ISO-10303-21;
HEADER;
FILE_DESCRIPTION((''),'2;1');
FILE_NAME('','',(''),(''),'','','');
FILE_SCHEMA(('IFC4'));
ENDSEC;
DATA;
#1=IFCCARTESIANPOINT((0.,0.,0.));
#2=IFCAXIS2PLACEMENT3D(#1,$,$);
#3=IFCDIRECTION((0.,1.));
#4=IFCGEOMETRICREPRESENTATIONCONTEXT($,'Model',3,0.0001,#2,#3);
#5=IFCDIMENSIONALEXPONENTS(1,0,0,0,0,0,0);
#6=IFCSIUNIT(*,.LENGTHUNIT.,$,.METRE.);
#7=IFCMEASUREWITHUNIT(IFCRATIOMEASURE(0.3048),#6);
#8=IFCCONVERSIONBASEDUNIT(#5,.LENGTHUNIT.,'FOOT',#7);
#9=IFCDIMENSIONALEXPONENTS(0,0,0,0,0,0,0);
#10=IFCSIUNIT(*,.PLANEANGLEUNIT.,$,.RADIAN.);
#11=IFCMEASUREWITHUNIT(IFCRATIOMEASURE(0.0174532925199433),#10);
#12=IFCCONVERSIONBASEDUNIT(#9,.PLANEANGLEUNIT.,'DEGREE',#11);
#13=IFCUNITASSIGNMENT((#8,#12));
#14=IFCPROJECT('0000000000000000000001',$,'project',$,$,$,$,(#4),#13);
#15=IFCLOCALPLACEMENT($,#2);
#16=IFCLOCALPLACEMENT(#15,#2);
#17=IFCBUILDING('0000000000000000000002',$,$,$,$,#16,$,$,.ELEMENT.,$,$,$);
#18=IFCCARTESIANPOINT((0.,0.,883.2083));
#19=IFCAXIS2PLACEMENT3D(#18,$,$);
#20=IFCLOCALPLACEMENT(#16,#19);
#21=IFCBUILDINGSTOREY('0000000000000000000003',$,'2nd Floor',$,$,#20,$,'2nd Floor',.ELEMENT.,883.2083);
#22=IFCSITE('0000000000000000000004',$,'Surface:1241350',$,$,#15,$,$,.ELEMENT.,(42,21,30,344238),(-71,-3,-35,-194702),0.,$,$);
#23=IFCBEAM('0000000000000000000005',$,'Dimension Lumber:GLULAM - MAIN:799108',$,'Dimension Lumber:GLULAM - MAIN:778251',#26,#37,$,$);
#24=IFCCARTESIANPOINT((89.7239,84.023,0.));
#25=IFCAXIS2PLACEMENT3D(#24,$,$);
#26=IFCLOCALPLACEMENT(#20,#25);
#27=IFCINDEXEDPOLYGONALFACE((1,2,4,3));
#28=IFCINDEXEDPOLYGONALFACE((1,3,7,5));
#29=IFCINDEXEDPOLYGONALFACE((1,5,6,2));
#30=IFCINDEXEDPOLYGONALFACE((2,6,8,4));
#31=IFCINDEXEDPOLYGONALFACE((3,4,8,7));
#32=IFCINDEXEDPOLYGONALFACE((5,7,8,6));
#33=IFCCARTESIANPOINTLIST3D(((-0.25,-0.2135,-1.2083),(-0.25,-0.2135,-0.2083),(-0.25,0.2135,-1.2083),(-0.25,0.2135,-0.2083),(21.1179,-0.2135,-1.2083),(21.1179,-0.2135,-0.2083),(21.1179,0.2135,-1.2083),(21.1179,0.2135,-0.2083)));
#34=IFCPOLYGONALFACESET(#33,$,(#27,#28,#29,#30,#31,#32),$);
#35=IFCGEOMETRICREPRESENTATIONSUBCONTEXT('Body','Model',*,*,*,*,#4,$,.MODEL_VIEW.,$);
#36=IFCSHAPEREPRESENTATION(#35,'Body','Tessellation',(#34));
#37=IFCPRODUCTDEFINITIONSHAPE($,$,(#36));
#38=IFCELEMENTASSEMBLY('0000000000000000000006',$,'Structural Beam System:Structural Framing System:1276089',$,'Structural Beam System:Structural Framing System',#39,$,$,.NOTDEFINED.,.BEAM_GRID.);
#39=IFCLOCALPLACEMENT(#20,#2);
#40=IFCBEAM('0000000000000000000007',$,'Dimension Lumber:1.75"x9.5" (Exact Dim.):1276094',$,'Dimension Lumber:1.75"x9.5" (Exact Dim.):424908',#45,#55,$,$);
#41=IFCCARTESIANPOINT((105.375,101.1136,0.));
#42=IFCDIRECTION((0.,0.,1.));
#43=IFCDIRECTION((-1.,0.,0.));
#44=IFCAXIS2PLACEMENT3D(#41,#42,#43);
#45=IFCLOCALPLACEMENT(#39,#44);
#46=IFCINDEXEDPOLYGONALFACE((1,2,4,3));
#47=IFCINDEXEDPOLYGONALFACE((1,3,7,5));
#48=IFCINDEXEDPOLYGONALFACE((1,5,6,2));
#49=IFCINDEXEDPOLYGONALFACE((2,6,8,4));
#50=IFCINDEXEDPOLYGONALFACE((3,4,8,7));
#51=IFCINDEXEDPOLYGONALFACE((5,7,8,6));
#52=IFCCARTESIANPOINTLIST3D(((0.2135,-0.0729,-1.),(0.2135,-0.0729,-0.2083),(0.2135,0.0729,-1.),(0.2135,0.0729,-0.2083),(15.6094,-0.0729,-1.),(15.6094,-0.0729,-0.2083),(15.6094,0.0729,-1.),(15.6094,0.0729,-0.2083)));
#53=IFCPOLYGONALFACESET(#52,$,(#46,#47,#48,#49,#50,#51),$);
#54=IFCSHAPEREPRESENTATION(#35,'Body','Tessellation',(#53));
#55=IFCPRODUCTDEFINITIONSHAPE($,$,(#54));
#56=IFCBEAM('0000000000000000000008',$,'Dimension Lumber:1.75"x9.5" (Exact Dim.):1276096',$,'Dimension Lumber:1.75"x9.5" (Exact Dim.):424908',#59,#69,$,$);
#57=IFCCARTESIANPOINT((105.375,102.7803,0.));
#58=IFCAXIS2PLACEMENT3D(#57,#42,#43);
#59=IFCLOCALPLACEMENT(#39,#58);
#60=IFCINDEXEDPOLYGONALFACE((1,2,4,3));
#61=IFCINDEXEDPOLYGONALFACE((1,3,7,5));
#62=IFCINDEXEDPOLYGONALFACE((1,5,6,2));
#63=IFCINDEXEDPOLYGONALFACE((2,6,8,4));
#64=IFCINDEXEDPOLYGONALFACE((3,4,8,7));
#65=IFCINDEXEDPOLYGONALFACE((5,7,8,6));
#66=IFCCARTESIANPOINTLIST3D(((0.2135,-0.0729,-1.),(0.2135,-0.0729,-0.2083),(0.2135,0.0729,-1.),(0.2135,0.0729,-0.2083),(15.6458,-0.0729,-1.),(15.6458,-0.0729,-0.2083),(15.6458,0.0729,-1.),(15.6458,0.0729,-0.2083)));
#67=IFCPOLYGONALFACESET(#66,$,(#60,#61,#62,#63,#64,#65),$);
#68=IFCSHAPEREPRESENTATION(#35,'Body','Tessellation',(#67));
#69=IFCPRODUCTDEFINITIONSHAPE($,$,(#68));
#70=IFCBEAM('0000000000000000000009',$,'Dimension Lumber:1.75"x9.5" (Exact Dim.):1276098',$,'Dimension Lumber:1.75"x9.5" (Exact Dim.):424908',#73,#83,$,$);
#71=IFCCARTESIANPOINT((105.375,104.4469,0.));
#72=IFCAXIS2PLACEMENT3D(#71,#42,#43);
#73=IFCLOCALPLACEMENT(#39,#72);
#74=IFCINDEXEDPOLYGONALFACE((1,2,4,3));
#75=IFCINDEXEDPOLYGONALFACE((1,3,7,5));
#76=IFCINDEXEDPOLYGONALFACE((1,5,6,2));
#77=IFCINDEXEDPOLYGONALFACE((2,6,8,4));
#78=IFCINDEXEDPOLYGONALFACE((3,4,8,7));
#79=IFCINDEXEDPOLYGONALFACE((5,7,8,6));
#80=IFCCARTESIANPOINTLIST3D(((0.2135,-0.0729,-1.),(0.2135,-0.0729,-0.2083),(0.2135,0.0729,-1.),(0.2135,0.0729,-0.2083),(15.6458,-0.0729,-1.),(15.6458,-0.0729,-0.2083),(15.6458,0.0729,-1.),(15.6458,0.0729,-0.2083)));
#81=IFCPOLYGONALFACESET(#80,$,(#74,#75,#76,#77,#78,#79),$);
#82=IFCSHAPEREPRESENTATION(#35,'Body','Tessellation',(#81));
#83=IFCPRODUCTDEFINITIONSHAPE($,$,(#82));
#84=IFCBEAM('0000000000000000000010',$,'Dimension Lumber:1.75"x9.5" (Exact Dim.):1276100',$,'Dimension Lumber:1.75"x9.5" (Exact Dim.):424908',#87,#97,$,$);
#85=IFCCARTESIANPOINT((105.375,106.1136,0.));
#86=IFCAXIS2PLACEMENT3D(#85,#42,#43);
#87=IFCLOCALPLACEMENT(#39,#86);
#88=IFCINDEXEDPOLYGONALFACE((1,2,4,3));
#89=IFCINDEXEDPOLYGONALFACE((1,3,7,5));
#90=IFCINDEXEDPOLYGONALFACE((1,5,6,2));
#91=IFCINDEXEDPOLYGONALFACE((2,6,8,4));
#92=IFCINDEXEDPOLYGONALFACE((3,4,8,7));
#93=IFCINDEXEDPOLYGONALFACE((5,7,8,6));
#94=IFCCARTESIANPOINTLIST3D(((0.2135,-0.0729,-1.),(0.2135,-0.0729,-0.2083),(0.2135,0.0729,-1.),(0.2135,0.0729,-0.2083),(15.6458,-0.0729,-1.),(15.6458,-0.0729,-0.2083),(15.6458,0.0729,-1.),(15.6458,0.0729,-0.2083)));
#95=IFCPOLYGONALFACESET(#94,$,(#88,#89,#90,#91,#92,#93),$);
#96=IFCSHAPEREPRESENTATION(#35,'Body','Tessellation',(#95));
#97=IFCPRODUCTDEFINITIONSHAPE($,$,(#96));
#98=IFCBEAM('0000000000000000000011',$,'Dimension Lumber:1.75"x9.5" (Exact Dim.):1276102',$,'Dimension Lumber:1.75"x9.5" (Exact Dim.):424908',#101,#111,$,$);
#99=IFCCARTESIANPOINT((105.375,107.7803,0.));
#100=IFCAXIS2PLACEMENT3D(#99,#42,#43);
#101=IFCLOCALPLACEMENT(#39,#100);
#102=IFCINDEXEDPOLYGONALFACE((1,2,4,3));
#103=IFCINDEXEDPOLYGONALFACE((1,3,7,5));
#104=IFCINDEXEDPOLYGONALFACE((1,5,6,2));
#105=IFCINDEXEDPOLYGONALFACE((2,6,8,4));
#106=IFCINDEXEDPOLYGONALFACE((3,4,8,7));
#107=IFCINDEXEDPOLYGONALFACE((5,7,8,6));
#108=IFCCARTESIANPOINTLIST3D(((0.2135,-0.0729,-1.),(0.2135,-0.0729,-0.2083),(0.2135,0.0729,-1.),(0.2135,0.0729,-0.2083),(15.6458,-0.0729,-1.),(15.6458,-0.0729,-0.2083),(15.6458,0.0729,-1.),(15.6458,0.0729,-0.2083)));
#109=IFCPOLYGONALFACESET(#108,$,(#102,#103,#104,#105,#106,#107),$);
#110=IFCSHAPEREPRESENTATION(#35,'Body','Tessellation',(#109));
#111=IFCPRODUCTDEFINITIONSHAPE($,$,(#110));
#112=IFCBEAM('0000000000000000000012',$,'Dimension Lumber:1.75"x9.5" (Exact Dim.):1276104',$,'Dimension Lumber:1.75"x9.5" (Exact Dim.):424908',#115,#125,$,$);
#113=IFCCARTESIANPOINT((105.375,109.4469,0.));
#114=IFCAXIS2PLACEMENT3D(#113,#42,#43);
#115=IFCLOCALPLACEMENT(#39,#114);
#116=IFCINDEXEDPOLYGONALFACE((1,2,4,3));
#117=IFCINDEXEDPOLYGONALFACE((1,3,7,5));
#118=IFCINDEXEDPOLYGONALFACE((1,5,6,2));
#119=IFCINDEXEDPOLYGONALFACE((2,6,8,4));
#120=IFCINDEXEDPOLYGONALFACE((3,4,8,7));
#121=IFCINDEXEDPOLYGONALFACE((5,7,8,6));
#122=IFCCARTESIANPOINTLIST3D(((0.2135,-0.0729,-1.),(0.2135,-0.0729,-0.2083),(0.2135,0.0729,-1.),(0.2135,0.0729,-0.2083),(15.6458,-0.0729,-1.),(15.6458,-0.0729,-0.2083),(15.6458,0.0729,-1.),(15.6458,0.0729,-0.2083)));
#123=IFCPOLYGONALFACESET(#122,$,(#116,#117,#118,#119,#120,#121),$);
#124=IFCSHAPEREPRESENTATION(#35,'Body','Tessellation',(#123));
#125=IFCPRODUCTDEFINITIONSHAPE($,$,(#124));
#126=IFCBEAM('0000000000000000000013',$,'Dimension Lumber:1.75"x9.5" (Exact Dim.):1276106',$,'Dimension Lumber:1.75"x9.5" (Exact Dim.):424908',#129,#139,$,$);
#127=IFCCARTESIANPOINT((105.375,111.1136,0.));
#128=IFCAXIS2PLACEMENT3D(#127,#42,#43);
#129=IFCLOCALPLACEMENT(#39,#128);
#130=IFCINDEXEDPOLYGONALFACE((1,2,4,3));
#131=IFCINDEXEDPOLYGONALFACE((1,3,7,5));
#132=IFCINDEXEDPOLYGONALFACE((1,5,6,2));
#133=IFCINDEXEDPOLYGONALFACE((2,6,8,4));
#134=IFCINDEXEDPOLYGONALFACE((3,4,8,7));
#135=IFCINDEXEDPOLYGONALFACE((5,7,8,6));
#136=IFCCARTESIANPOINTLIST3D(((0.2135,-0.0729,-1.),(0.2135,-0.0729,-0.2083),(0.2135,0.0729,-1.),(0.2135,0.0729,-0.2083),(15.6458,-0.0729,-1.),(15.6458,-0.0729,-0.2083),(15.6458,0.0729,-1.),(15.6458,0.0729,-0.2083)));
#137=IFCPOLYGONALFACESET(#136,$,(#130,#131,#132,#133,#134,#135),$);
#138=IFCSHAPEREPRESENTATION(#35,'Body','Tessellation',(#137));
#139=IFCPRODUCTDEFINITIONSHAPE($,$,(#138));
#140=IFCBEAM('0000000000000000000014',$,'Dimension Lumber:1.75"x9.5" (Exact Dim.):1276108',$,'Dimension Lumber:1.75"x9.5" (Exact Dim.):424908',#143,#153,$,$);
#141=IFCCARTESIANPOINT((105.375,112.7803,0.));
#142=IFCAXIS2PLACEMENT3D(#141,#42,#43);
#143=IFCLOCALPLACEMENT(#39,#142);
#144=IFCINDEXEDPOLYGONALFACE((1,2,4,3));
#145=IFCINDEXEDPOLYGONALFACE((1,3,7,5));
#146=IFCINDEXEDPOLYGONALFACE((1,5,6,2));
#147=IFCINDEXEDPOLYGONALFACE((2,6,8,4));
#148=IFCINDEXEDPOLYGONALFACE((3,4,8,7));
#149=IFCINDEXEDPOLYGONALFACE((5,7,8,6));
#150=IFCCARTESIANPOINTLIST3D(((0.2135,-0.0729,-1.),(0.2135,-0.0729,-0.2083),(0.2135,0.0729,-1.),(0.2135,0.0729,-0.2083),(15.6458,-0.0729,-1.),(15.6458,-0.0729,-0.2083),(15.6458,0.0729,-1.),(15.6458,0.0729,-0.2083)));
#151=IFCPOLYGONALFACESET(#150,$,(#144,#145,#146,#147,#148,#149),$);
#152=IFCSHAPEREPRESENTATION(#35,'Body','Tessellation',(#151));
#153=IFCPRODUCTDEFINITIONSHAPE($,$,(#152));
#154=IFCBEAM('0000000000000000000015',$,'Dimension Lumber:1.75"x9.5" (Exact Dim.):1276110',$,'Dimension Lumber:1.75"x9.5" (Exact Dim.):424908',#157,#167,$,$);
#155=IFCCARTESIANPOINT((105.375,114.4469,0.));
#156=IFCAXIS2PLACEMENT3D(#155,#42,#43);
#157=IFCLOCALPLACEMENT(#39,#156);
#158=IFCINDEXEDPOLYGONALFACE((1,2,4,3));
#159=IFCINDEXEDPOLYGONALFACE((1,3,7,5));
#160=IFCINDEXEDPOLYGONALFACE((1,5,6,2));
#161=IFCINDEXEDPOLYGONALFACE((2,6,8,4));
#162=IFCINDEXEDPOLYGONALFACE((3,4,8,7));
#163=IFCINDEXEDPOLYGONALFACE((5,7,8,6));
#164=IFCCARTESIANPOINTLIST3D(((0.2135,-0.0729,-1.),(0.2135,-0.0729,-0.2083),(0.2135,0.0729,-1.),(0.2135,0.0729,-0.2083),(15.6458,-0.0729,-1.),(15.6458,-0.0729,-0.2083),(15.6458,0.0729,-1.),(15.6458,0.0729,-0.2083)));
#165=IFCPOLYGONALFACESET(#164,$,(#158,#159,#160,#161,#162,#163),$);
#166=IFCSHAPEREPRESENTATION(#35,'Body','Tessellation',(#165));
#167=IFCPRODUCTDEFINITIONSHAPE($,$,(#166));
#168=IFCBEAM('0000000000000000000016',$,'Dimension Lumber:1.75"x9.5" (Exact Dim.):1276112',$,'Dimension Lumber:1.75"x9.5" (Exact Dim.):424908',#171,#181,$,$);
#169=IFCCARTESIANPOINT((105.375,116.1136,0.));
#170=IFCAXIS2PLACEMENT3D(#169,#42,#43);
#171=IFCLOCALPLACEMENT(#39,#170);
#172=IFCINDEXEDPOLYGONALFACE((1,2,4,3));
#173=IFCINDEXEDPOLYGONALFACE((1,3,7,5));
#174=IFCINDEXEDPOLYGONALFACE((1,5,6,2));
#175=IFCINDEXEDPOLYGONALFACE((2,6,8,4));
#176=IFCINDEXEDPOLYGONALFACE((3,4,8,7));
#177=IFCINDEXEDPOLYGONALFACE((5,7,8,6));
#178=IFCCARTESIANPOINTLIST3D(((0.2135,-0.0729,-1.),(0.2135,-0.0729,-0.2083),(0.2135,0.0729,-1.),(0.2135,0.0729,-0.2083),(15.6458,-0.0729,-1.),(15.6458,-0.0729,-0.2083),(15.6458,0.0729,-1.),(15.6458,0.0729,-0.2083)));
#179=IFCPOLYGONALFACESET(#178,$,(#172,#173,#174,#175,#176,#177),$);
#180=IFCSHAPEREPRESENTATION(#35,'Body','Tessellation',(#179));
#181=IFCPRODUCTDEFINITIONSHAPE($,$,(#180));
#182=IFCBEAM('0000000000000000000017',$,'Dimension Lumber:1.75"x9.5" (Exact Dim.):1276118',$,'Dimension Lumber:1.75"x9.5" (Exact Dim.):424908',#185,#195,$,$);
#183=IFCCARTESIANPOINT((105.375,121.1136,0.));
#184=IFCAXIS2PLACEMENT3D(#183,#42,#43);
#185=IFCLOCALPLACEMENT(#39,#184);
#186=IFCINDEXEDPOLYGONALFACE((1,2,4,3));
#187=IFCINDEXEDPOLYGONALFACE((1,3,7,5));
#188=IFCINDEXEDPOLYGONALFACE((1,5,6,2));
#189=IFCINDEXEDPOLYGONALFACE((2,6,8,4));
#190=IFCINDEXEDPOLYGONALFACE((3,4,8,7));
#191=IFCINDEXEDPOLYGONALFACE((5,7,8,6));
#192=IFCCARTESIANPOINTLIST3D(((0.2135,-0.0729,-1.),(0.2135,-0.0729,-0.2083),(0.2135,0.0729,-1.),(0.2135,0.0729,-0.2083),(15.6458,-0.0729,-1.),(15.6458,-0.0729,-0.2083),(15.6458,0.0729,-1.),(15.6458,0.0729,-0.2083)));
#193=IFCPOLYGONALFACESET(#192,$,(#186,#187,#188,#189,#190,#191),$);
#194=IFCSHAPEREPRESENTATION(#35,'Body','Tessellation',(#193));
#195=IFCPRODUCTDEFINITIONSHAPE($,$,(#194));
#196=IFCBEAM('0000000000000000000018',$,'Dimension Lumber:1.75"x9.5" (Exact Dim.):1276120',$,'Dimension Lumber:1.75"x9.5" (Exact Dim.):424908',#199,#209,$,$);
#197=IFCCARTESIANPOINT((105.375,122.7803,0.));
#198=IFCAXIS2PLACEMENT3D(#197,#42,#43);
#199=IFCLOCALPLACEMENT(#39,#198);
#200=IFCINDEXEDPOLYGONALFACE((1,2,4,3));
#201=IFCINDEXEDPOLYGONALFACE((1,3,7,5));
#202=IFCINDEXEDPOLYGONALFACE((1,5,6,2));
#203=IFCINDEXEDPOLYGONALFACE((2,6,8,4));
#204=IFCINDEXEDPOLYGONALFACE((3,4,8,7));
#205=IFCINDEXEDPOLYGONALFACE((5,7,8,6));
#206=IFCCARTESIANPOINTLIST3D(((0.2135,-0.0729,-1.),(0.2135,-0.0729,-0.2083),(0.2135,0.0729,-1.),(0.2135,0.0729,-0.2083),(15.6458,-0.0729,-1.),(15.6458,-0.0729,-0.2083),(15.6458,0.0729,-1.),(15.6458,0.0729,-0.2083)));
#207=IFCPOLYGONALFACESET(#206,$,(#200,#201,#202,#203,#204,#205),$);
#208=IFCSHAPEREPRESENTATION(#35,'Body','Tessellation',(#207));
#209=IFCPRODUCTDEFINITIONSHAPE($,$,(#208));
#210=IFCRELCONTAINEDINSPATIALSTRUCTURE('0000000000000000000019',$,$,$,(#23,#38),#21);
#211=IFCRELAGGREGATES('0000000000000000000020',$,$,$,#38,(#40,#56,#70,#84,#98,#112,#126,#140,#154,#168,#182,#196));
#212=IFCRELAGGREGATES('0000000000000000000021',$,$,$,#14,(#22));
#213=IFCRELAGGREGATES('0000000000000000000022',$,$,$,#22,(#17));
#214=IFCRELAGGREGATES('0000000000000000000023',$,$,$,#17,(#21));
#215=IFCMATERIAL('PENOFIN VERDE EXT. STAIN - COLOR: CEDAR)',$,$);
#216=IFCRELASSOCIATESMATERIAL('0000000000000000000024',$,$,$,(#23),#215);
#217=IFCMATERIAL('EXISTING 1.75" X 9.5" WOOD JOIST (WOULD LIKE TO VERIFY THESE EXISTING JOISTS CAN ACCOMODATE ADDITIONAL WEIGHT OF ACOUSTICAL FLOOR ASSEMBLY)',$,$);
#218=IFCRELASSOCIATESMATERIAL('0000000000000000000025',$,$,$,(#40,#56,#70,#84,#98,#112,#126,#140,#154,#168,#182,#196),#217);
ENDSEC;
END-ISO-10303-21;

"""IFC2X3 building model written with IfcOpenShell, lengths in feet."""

from ifc_helpers import new_model, entity, si_unit, converted_unit, direction, frame, frame_2d, origin, origin_2d_with_axis, place, context, subcontext, project, spatial, rectangle, extrude, material, element, aggregate, save


model = new_model("IFC2X3")

# Units and contexts
model_context = context("Model", 3, precision=0.0001, world=origin(), true_north=direction((0.0, 1.0)))
body_context = subcontext(model_context, "Body", "Model", "MODEL_VIEW")
ifc_project = project(units=[converted_unit("LENGTHUNIT", "FOOT", entity("IfcRatioMeasure", 0.3048), si_unit("LENGTHUNIT", "METRE"), dimensions=[1, 0, 0, 0, 0, 0, 0]), converted_unit("PLANEANGLEUNIT", "DEGREE", entity("IfcRatioMeasure", 0.0174532925199433), si_unit("PLANEANGLEUNIT", "RADIAN"), dimensions=[0, 0, 0, 0, 0, 0, 0])], contexts=[model_context])

# Site, building, storey
site_placement = place(None, origin())
site = spatial("IfcSite", under=ifc_project, at=site_placement, Name="Surface:1241350", CompositionType="ELEMENT", RefLatitude=(42, 21, 30, 344238), RefLongitude=(-71, -3, -35, -194702), RefElevation=0.0)
building_placement = place(site_placement, origin())
building = spatial("IfcBuilding", under=site, at=building_placement, CompositionType="ELEMENT")
storey_placement = place(building_placement, frame((0.0, 0.0, 883.2083)))
storey = spatial("IfcBuildingStorey", under=building, at=storey_placement, Name="2nd Floor", LongName="2nd Floor", CompositionType="ELEMENT", Elevation=883.2083)

# Beam
ifc_material_1 = material(Name="PENOFIN VERDE EXT. STAIN - COLOR: CEDAR)")
beam_1_placement = place(storey_placement, frame((89.7239, 84.023, 0.0)))
element("IfcBeam", 1, at=beam_1_placement, inside=storey, material=ifc_material_1, Name="Dimension Lumber:GLULAM - MAIN:799108", ObjectType="Dimension Lumber:GLULAM - MAIN:778251", context=body_context, shape_type="SweptSolid", body=[
    extrude(rectangle(XDim=1.0, YDim=0.4271, at=frame_2d((0.0, 0.0), x_axis=(1.0, 0.0))), frame((-0.25, 0.0, -0.7083), z_axis=(1.0, 0.0, 0.0), x_axis=(0.0, 0.0, -1.0)), (0.0, 0.0, 1.0), 21.3679),
])

# Element assembly, beams
assembly_1_placement = place(storey_placement, origin())
assembly_1 = element("IfcElementAssembly", 2, at=assembly_1_placement, inside=storey, Name="Structural Beam System:Structural Framing System:1276089", ObjectType="Structural Beam System:Structural Framing System", AssemblyPlace="NOTDEFINED", PredefinedType="BEAM_GRID")
ifc_material_2 = material(Name="EXISTING 1.75\" X 9.5\" WOOD JOIST (WOULD LIKE TO VERIFY THESE EXISTING JOISTS CAN ACCOMODATE ADDITIONAL WEIGHT OF ACOUSTICAL FLOOR ASSEMBLY)")
beam_2_placement = place(assembly_1_placement, frame((105.375, 101.1136, 0.0), z_axis=(0.0, 0.0, 1.0), x_axis=(-1.0, 0.0, 0.0)))
beam_2 = element("IfcBeam", 3, at=beam_2_placement, material=ifc_material_2, Name="Dimension Lumber:1.75\"x9.5\" (Exact Dim.):1276094", ObjectType="Dimension Lumber:1.75\"x9.5\" (Exact Dim.):424908", context=body_context, shape_type="SweptSolid", body=[
    extrude(rectangle(XDim=0.7917, YDim=0.1458, at=origin_2d_with_axis()), frame((0.2135, 0.0, -0.6042), z_axis=(1.0, 0.0, 0.0), x_axis=(0.0, 0.0, -1.0)), (0.0, 0.0, 1.0), 15.3958),
])
beam_3_placement = place(assembly_1_placement, frame((105.375, 102.7803, 0.0), z_axis=(0.0, 0.0, 1.0), x_axis=(-1.0, 0.0, 0.0)))
beam_3 = element("IfcBeam", 4, at=beam_3_placement, material=ifc_material_2, Name="Dimension Lumber:1.75\"x9.5\" (Exact Dim.):1276096", ObjectType="Dimension Lumber:1.75\"x9.5\" (Exact Dim.):424908", context=body_context, shape_type="SweptSolid", body=[
    extrude(rectangle(XDim=0.7917, YDim=0.1458, at=origin_2d_with_axis()), frame((0.2135, 0.0, -0.6042), z_axis=(1.0, 0.0, 0.0), x_axis=(0.0, 0.0, -1.0)), (0.0, 0.0, 1.0), 15.4323),
])
beam_4_placement = place(assembly_1_placement, frame((105.375, 104.4469, 0.0), z_axis=(0.0, 0.0, 1.0), x_axis=(-1.0, 0.0, 0.0)))
beam_4 = element("IfcBeam", 5, at=beam_4_placement, material=ifc_material_2, Name="Dimension Lumber:1.75\"x9.5\" (Exact Dim.):1276098", ObjectType="Dimension Lumber:1.75\"x9.5\" (Exact Dim.):424908", context=body_context, shape_type="SweptSolid", body=[
    extrude(rectangle(XDim=0.7917, YDim=0.1458, at=origin_2d_with_axis()), frame((0.2135, 0.0, -0.6042), z_axis=(1.0, 0.0, 0.0), x_axis=(0.0, 0.0, -1.0)), (0.0, 0.0, 1.0), 15.4323),
])
beam_5_placement = place(assembly_1_placement, frame((105.375, 106.1136, 0.0), z_axis=(0.0, 0.0, 1.0), x_axis=(-1.0, 0.0, 0.0)))
beam_5 = element("IfcBeam", 6, at=beam_5_placement, material=ifc_material_2, Name="Dimension Lumber:1.75\"x9.5\" (Exact Dim.):1276100", ObjectType="Dimension Lumber:1.75\"x9.5\" (Exact Dim.):424908", context=body_context, shape_type="SweptSolid", body=[
    extrude(rectangle(XDim=0.7917, YDim=0.1458, at=origin_2d_with_axis()), frame((0.2135, 0.0, -0.6042), z_axis=(1.0, 0.0, 0.0), x_axis=(0.0, 0.0, -1.0)), (0.0, 0.0, 1.0), 15.4323),
])
beam_6_placement = place(assembly_1_placement, frame((105.375, 107.7803, 0.0), z_axis=(0.0, 0.0, 1.0), x_axis=(-1.0, 0.0, 0.0)))
beam_6 = element("IfcBeam", 7, at=beam_6_placement, material=ifc_material_2, Name="Dimension Lumber:1.75\"x9.5\" (Exact Dim.):1276102", ObjectType="Dimension Lumber:1.75\"x9.5\" (Exact Dim.):424908", context=body_context, shape_type="SweptSolid", body=[
    extrude(rectangle(XDim=0.7917, YDim=0.1458, at=origin_2d_with_axis()), frame((0.2135, 0.0, -0.6042), z_axis=(1.0, 0.0, 0.0), x_axis=(0.0, 0.0, -1.0)), (0.0, 0.0, 1.0), 15.4323),
])
beam_7_placement = place(assembly_1_placement, frame((105.375, 109.4469, 0.0), z_axis=(0.0, 0.0, 1.0), x_axis=(-1.0, 0.0, 0.0)))
beam_7 = element("IfcBeam", 8, at=beam_7_placement, material=ifc_material_2, Name="Dimension Lumber:1.75\"x9.5\" (Exact Dim.):1276104", ObjectType="Dimension Lumber:1.75\"x9.5\" (Exact Dim.):424908", context=body_context, shape_type="SweptSolid", body=[
    extrude(rectangle(XDim=0.7917, YDim=0.1458, at=origin_2d_with_axis()), frame((0.2135, 0.0, -0.6042), z_axis=(1.0, 0.0, 0.0), x_axis=(0.0, 0.0, -1.0)), (0.0, 0.0, 1.0), 15.4323),
])
beam_8_placement = place(assembly_1_placement, frame((105.375, 111.1136, 0.0), z_axis=(0.0, 0.0, 1.0), x_axis=(-1.0, 0.0, 0.0)))
beam_8 = element("IfcBeam", 9, at=beam_8_placement, material=ifc_material_2, Name="Dimension Lumber:1.75\"x9.5\" (Exact Dim.):1276106", ObjectType="Dimension Lumber:1.75\"x9.5\" (Exact Dim.):424908", context=body_context, shape_type="SweptSolid", body=[
    extrude(rectangle(XDim=0.7917, YDim=0.1458, at=origin_2d_with_axis()), frame((0.2135, 0.0, -0.6042), z_axis=(1.0, 0.0, 0.0), x_axis=(0.0, 0.0, -1.0)), (0.0, 0.0, 1.0), 15.4323),
])
beam_9_placement = place(assembly_1_placement, frame((105.375, 112.7803, 0.0), z_axis=(0.0, 0.0, 1.0), x_axis=(-1.0, 0.0, 0.0)))
beam_9 = element("IfcBeam", 10, at=beam_9_placement, material=ifc_material_2, Name="Dimension Lumber:1.75\"x9.5\" (Exact Dim.):1276108", ObjectType="Dimension Lumber:1.75\"x9.5\" (Exact Dim.):424908", context=body_context, shape_type="SweptSolid", body=[
    extrude(rectangle(XDim=0.7917, YDim=0.1458, at=origin_2d_with_axis()), frame((0.2135, 0.0, -0.6042), z_axis=(1.0, 0.0, 0.0), x_axis=(0.0, 0.0, -1.0)), (0.0, 0.0, 1.0), 15.4323),
])
beam_10_placement = place(assembly_1_placement, frame((105.375, 114.4469, 0.0), z_axis=(0.0, 0.0, 1.0), x_axis=(-1.0, 0.0, 0.0)))
beam_10 = element("IfcBeam", 11, at=beam_10_placement, material=ifc_material_2, Name="Dimension Lumber:1.75\"x9.5\" (Exact Dim.):1276110", ObjectType="Dimension Lumber:1.75\"x9.5\" (Exact Dim.):424908", context=body_context, shape_type="SweptSolid", body=[
    extrude(rectangle(XDim=0.7917, YDim=0.1458, at=origin_2d_with_axis()), frame((0.2135, 0.0, -0.6042), z_axis=(1.0, 0.0, 0.0), x_axis=(0.0, 0.0, -1.0)), (0.0, 0.0, 1.0), 15.4323),
])
beam_11_placement = place(assembly_1_placement, frame((105.375, 116.1136, 0.0), z_axis=(0.0, 0.0, 1.0), x_axis=(-1.0, 0.0, 0.0)))
beam_11 = element("IfcBeam", 12, at=beam_11_placement, material=ifc_material_2, Name="Dimension Lumber:1.75\"x9.5\" (Exact Dim.):1276112", ObjectType="Dimension Lumber:1.75\"x9.5\" (Exact Dim.):424908", context=body_context, shape_type="SweptSolid", body=[
    extrude(rectangle(XDim=0.7917, YDim=0.1458, at=origin_2d_with_axis()), frame((0.2135, 0.0, -0.6042), z_axis=(1.0, 0.0, 0.0), x_axis=(0.0, 0.0, -1.0)), (0.0, 0.0, 1.0), 15.4323),
])
beam_12_placement = place(assembly_1_placement, frame((105.375, 121.1136, 0.0), z_axis=(0.0, 0.0, 1.0), x_axis=(-1.0, 0.0, 0.0)))
beam_12 = element("IfcBeam", 13, at=beam_12_placement, material=ifc_material_2, Name="Dimension Lumber:1.75\"x9.5\" (Exact Dim.):1276118", ObjectType="Dimension Lumber:1.75\"x9.5\" (Exact Dim.):424908", context=body_context, shape_type="SweptSolid", body=[
    extrude(rectangle(XDim=0.7917, YDim=0.1458, at=origin_2d_with_axis()), frame((0.2135, 0.0, -0.6042), z_axis=(1.0, 0.0, 0.0), x_axis=(0.0, 0.0, -1.0)), (0.0, 0.0, 1.0), 15.4323),
])
beam_13_placement = place(assembly_1_placement, frame((105.375, 122.7803, 0.0), z_axis=(0.0, 0.0, 1.0), x_axis=(-1.0, 0.0, 0.0)))
beam_13 = element("IfcBeam", 14, at=beam_13_placement, material=ifc_material_2, Name="Dimension Lumber:1.75\"x9.5\" (Exact Dim.):1276120", ObjectType="Dimension Lumber:1.75\"x9.5\" (Exact Dim.):424908", context=body_context, shape_type="SweptSolid", body=[
    extrude(rectangle(XDim=0.7917, YDim=0.1458, at=frame_2d((0.0, 0.0), x_axis=(1.0, 0.0))), frame((0.2135, 0.0, -0.6042), z_axis=(1.0, 0.0, 0.0), x_axis=(0.0, 0.0, -1.0)), (0.0, 0.0, 1.0), 15.4323),
])
aggregate(assembly_1, [beam_2, beam_3, beam_4, beam_5, beam_6, beam_7, beam_8, beam_9, beam_10, beam_11, beam_12, beam_13])

save(model, "model.ifc")
